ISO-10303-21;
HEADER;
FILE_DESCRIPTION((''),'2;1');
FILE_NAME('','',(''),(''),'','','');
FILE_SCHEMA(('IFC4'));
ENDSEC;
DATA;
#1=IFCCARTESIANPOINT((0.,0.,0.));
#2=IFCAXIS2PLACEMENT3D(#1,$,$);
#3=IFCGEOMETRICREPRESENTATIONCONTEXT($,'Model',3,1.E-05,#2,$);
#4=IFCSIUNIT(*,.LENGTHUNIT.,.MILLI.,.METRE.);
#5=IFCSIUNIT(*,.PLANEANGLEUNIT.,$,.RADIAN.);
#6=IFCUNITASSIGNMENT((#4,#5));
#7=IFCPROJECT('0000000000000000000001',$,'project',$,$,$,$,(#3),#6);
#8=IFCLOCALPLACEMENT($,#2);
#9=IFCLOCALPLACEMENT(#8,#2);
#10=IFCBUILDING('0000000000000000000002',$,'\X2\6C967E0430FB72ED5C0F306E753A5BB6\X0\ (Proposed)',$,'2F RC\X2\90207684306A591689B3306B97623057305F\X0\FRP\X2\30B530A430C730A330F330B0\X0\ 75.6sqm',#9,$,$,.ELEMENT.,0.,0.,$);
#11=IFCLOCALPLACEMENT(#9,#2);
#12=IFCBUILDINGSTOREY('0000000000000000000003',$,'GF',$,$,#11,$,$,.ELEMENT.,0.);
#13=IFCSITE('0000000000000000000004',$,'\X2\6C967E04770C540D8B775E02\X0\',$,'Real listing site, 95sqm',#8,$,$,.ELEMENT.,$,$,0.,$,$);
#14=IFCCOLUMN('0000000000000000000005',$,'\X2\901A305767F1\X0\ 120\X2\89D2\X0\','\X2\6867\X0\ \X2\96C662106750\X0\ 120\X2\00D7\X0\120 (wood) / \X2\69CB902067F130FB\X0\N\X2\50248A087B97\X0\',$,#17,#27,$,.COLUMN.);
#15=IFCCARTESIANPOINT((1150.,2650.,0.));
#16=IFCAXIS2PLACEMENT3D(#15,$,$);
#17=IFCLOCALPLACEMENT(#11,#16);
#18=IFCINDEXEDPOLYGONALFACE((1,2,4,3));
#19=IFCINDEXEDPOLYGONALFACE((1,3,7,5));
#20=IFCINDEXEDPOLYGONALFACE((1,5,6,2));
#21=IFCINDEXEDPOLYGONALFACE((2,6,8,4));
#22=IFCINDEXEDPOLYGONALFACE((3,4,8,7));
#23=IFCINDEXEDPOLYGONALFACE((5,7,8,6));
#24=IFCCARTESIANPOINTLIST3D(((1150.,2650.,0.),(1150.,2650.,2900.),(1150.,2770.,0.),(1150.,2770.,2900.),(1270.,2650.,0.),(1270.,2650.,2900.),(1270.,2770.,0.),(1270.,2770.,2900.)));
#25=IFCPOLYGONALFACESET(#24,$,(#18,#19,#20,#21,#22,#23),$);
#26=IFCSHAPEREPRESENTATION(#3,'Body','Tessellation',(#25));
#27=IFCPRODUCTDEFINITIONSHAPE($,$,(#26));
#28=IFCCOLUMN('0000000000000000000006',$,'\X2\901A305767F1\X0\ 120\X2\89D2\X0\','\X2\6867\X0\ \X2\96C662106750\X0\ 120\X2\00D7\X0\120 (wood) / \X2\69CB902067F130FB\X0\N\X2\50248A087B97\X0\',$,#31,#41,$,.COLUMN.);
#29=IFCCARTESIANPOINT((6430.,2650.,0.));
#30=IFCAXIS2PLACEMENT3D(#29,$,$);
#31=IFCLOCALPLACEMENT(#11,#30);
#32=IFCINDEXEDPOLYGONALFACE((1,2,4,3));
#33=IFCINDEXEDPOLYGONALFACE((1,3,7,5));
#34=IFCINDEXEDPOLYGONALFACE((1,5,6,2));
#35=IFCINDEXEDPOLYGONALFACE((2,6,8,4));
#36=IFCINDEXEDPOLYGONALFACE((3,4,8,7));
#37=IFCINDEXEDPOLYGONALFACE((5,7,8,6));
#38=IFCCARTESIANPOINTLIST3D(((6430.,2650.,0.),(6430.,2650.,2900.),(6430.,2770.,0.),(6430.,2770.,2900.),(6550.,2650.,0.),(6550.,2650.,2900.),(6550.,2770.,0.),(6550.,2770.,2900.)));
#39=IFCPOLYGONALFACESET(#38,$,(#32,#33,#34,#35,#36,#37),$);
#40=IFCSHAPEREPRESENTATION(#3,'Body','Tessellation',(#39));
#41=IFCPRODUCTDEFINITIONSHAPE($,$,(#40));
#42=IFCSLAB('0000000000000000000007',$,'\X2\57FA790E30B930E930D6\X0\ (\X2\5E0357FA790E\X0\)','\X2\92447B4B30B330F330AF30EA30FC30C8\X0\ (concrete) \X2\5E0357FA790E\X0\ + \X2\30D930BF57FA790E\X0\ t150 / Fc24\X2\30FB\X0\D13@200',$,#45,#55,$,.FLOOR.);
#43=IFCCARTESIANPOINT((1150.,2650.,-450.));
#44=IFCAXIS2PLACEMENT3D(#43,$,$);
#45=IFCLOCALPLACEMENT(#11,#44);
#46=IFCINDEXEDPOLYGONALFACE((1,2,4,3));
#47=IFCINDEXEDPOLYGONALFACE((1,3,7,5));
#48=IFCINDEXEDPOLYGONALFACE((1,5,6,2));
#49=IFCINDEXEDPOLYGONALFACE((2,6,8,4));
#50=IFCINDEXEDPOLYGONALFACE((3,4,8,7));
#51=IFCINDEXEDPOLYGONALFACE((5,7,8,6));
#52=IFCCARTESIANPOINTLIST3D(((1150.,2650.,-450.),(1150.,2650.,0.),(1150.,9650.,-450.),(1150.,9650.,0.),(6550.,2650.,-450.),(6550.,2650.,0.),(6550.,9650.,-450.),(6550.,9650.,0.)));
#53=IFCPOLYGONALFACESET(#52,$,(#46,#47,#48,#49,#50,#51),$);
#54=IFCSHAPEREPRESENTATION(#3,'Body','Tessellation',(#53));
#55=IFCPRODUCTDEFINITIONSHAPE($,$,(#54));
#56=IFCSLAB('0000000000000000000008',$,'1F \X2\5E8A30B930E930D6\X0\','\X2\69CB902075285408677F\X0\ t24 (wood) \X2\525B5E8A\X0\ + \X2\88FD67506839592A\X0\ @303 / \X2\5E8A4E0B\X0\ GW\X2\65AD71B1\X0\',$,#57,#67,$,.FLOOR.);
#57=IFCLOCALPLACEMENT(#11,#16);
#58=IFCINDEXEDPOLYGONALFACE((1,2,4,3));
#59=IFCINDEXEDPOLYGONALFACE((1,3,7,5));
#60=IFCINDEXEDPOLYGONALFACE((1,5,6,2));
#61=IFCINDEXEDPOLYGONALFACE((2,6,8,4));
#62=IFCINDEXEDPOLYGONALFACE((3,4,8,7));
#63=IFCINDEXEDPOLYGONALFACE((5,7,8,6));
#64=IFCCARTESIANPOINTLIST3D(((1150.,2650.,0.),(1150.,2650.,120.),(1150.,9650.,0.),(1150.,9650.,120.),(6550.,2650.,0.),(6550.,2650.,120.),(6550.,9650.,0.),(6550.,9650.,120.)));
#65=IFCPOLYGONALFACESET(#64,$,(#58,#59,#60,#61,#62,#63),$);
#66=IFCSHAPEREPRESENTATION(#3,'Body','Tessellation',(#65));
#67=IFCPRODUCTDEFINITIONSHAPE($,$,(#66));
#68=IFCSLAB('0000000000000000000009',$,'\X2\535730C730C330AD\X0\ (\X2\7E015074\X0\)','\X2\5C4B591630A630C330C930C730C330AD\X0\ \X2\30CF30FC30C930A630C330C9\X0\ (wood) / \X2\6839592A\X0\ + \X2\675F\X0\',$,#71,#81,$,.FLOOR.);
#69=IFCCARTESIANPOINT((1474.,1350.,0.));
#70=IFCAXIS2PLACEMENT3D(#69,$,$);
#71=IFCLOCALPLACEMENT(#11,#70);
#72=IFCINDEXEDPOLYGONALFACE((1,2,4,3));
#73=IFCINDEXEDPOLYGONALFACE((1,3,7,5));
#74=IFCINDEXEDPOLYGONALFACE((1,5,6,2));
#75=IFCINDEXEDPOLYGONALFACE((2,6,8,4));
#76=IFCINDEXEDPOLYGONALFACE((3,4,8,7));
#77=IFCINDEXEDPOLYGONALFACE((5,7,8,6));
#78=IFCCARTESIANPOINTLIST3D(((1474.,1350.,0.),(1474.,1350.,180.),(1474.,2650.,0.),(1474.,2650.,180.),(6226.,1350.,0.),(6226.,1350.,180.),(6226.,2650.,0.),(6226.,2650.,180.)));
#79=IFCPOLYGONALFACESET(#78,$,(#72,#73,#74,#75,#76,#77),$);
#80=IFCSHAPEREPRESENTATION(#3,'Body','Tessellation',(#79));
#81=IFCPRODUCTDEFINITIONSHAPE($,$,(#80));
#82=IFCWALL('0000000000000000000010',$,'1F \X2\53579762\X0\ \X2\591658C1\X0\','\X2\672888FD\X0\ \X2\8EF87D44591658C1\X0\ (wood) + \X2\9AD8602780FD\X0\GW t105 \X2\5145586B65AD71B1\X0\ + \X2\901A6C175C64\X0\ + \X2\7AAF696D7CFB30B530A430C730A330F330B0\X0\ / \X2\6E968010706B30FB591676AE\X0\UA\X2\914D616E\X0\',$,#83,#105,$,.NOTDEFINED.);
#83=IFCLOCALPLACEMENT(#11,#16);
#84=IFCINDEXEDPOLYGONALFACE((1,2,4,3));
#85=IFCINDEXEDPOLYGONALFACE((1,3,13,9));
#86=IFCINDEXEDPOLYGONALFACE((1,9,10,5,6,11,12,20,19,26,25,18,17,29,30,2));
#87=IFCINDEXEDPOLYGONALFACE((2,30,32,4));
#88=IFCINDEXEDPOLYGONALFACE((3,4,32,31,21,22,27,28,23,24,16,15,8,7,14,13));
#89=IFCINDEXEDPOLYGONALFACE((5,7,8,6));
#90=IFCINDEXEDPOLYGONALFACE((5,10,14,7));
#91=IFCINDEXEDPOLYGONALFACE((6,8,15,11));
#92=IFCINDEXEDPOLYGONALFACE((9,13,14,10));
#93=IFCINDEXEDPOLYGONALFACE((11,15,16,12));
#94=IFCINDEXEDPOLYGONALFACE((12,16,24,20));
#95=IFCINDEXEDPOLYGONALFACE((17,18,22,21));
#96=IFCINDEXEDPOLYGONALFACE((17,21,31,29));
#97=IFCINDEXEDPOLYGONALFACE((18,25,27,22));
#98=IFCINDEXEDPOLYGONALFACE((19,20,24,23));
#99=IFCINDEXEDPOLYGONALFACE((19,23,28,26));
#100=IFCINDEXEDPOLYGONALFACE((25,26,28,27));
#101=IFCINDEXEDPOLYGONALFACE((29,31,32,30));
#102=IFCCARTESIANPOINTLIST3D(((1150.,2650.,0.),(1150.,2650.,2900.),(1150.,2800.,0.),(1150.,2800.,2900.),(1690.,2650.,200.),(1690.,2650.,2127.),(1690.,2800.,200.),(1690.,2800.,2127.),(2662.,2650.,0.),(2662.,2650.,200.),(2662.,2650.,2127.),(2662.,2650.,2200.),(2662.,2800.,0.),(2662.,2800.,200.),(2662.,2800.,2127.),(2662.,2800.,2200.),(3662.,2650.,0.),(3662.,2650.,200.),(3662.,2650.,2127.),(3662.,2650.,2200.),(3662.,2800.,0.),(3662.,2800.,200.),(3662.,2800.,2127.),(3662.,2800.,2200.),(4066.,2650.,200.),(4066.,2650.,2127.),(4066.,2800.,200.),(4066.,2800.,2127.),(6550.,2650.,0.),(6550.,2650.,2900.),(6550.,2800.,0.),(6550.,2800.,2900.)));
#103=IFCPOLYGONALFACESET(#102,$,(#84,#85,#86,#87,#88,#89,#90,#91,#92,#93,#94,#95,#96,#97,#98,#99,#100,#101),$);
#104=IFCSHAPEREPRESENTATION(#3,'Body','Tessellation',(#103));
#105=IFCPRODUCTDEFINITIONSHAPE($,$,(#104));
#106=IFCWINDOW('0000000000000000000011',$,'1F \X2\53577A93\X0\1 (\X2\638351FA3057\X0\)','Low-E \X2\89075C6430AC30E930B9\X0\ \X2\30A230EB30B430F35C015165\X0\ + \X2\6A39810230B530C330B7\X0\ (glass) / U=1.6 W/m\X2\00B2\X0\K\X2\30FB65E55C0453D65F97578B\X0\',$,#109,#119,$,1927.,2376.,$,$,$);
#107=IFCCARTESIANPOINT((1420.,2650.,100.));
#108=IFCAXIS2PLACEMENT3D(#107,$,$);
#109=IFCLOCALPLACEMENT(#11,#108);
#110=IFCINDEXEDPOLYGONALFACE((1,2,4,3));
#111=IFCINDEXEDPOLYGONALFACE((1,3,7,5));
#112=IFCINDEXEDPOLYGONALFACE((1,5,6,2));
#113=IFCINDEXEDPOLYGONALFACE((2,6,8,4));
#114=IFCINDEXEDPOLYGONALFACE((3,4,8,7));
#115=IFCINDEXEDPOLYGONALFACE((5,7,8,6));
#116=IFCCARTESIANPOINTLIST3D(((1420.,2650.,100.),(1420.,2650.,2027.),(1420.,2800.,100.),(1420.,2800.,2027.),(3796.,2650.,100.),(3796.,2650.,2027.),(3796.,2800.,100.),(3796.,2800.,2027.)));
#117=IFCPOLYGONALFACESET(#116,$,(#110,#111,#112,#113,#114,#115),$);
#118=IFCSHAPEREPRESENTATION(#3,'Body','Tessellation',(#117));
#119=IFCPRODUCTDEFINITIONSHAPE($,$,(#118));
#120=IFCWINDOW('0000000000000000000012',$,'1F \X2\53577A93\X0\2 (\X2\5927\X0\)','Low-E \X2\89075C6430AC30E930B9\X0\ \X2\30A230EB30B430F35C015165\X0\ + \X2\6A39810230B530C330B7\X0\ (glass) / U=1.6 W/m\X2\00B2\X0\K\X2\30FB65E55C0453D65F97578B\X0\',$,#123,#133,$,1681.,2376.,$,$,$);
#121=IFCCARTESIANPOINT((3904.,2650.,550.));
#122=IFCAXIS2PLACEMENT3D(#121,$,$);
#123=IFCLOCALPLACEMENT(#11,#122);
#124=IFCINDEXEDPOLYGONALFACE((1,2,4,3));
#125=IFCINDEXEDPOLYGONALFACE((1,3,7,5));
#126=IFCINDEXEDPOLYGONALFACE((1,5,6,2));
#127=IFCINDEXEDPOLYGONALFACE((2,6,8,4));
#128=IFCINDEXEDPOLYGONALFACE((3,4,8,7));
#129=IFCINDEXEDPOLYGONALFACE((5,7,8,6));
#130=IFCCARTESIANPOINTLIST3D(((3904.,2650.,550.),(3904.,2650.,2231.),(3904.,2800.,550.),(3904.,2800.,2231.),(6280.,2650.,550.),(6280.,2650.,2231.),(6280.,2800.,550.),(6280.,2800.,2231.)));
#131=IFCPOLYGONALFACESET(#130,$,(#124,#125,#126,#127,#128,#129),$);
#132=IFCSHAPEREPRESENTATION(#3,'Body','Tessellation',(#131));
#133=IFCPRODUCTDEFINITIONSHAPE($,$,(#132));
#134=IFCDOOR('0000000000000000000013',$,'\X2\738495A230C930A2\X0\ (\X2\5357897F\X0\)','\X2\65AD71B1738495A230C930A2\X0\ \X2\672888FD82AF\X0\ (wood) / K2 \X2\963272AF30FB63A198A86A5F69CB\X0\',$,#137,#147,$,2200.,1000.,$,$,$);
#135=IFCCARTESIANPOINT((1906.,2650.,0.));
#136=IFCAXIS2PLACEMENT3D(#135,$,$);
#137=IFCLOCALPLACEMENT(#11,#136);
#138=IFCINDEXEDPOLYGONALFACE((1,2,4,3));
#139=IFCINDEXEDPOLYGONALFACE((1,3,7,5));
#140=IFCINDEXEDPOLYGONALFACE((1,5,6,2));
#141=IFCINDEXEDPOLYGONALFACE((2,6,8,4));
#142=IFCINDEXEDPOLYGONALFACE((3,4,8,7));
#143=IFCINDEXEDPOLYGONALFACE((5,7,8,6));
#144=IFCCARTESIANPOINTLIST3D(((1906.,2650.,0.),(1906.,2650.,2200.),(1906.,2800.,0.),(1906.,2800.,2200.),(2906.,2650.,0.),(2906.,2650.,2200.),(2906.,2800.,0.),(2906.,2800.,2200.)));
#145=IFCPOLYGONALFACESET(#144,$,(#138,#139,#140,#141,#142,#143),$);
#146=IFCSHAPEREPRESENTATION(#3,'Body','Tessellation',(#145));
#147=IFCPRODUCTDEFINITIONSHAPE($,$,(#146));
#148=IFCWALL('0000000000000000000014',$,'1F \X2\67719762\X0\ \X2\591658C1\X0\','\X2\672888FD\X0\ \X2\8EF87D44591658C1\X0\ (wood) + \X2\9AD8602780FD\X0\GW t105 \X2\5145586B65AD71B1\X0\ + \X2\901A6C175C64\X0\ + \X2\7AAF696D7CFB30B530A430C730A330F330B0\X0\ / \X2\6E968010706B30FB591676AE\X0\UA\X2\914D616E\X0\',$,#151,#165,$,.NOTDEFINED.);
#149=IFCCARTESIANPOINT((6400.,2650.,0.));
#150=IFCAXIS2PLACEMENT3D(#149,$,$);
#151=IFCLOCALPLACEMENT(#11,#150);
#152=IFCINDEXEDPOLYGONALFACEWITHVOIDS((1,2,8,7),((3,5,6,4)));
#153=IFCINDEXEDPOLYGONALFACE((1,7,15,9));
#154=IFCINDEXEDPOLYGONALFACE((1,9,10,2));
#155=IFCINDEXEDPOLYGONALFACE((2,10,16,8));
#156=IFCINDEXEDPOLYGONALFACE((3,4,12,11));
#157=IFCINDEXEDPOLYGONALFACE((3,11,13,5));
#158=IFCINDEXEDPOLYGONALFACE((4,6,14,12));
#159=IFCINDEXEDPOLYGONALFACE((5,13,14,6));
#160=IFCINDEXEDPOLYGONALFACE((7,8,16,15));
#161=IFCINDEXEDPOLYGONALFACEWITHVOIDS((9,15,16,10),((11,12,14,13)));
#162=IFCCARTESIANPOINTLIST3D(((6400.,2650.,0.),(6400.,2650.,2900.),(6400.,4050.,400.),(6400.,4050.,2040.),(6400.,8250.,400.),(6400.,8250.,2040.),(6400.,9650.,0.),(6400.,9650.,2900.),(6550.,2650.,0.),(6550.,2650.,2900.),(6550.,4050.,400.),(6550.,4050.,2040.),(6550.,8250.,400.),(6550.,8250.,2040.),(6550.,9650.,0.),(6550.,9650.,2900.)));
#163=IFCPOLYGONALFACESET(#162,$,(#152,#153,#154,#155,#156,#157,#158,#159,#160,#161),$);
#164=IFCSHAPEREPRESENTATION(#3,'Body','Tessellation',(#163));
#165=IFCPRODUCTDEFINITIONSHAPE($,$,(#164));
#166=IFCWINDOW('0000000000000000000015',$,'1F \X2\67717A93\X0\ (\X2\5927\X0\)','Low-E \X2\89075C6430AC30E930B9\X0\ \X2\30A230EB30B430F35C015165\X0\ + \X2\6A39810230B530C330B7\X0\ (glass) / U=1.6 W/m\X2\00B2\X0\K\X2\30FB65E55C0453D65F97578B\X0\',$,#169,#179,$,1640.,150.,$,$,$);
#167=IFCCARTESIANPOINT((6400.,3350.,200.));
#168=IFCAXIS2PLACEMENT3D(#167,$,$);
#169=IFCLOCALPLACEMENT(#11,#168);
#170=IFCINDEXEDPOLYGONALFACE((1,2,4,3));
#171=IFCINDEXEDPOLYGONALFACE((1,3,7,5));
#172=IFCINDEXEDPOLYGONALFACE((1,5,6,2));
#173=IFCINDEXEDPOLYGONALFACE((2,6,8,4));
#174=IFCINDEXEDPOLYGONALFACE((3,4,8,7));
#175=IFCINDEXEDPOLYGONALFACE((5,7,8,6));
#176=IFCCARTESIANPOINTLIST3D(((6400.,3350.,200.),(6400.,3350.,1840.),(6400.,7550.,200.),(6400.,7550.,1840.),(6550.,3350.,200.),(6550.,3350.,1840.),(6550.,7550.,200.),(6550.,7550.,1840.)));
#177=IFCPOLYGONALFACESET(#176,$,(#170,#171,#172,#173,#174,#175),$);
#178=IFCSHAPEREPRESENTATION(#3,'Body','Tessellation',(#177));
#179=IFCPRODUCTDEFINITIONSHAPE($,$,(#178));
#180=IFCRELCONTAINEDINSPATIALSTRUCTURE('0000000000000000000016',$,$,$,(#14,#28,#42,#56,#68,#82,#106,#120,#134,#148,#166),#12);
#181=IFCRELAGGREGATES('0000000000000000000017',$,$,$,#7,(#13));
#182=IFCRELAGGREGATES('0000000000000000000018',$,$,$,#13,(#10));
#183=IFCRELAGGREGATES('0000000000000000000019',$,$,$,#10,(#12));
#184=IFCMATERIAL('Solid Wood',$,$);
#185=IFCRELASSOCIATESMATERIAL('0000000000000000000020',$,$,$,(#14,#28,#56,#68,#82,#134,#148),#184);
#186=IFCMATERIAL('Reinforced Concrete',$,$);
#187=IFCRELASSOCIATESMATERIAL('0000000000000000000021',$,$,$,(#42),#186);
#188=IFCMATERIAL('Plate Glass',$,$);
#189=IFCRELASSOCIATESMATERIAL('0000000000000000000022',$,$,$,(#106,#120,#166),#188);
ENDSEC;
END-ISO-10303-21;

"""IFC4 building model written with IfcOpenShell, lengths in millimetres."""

from ifc_helpers import new_model, si_unit, frame, frame_2d, origin, place, context, project, spatial, rectangle, extrude, material, element, fill, save


model = new_model("IFC4")

# Units and contexts
model_context = context("Model", 3, precision=1e-05, world=origin())
ifc_project = project(units=[si_unit("LENGTHUNIT", "METRE", prefix="MILLI"), si_unit("PLANEANGLEUNIT", "RADIAN")], contexts=[model_context])

# Site, building, storey
site_placement = place(None, origin())
site = spatial("IfcSite", under=ifc_project, at=site_placement, Name="沖縄県名護市", ObjectType="Real listing site, 95sqm", CompositionType="ELEMENT", RefElevation=0.0)
building_placement = place(site_placement, origin())
building = spatial("IfcBuilding", under=site, at=building_placement, Name="沖縄・狭小の町家 (Proposed)", ObjectType="2F RC造的な外観に面したFRPサイディング 75.6sqm", CompositionType="ELEMENT", ElevationOfRefHeight=0.0, ElevationOfTerrain=0.0)
storey_placement = place(building_placement, origin())
storey = spatial("IfcBuildingStorey", under=building, at=storey_placement, Name="GF", CompositionType="ELEMENT", Elevation=0.0)

# Columns
ifc_material_1 = material(Name="Solid Wood")
column_1_placement = place(storey_placement, frame((1150.0, 2650.0, 0.0)))
element("IfcColumn", 1, at=column_1_placement, inside=storey, material=ifc_material_1, Name="通し柱 120角", Description="桧 集成材 120×120 (wood) / 構造柱・N値計算", PredefinedType="COLUMN", context=model_context, shape_type="SweptSolid", body=[
    extrude(rectangle(XDim=120.0, YDim=120.0, at=frame_2d((60.0, 60.0))), frame((1150.0, 2650.0, 0.0)), (0.0, 0.0, 1.0), 2900.0),
])
column_2_placement = place(storey_placement, frame((6430.0, 2650.0, 0.0)))
element("IfcColumn", 2, at=column_2_placement, inside=storey, material=ifc_material_1, Name="通し柱 120角", Description="桧 集成材 120×120 (wood) / 構造柱・N値計算", PredefinedType="COLUMN", context=model_context, shape_type="SweptSolid", body=[
    extrude(rectangle(XDim=120.0, YDim=120.0, at=frame_2d((60.0, 60.0))), frame((6430.0, 2650.0, 0.0)), (0.0, 0.0, 1.0), 2900.0),
])

# Slabs
ifc_material_2 = material(Name="Reinforced Concrete")
slab_1_placement = place(storey_placement, frame((1150.0, 2650.0, -450.0)))
element("IfcSlab", 3, at=slab_1_placement, inside=storey, material=ifc_material_2, Name="基礎スラブ (布基礎)", Description="鉄筋コンクリート (concrete) 布基礎 + ベタ基礎 t150 / Fc24・D13@200", PredefinedType="FLOOR", context=model_context, shape_type="SweptSolid", body=[
    extrude(rectangle(XDim=5400.0, YDim=7000.0, at=frame_2d((2700.0, 3500.0))), frame((1150.0, 2650.0, -450.0)), (0.0, 0.0, 1.0), 450.0),
])
slab_2_placement = place(storey_placement, frame((1150.0, 2650.0, 0.0)))
element("IfcSlab", 4, at=slab_2_placement, inside=storey, material=ifc_material_1, Name="1F 床スラブ", Description="構造用合板 t24 (wood) 剛床 + 製材根太 @303 / 床下 GW断熱", PredefinedType="FLOOR", context=model_context, shape_type="SweptSolid", body=[
    extrude(rectangle(XDim=5400.0, YDim=7000.0, at=frame_2d((2700.0, 3500.0))), frame((1150.0, 2650.0, 0.0)), (0.0, 0.0, 1.0), 120.0),
])
slab_3_placement = place(storey_placement, frame((1474.0, 1350.0, 0.0)))
element("IfcSlab", 5, at=slab_3_placement, inside=storey, material=ifc_material_1, Name="南デッキ (縁側)", Description="屋外ウッドデッキ ハードウッド (wood) / 根太 + 束", PredefinedType="FLOOR", context=model_context, shape_type="SweptSolid", body=[
    extrude(rectangle(XDim=4752.0, YDim=1300.0, at=frame_2d((2376.0, 650.0))), frame((1474.0, 1350.0, 0.0)), (0.0, 0.0, 1.0), 180.0),
])

# Wall, openings, windows, door
wall_1_placement = place(storey_placement, frame((1150.0, 2650.0, 0.0)))
wall_1 = element("IfcWall", 6, at=wall_1_placement, inside=storey, material=ifc_material_1, Name="1F 南面 外壁", Description="木製 軸組外壁 (wood) + 高性能GW t105 充填断熱 + 通気層 + 窯業系サイディング / 準耐火・外皮UA配慮", PredefinedType="NOTDEFINED", context=model_context, shape_type="SweptSolid", body=[
    extrude(rectangle(XDim=5400.0, YDim=150.0, at=frame_2d((2700.0, 75.0))), frame((1150.0, 2650.0, 0.0)), (0.0, 0.0, 1.0), 2900.0),
])
opening_1_placement = place(storey_placement, frame((1420.0, 2650.0, 100.0)))
opening_1 = element("IfcOpeningElement", 7, at=opening_1_placement, cuts=wall_1, PredefinedType="NOTDEFINED", context=model_context, shape_type="SweptSolid", body=[
    extrude(rectangle(XDim=2376.0, YDim=150.0, at=frame_2d((1188.0, 75.0))), frame((1420.0, 2650.0, 100.0)), (0.0, 0.0, 1.0), 1927.0),
])
opening_2_placement = place(storey_placement, frame((3904.0, 2650.0, 550.0)))
opening_2 = element("IfcOpeningElement", 8, at=opening_2_placement, cuts=wall_1, PredefinedType="NOTDEFINED", context=model_context, shape_type="SweptSolid", body=[
    extrude(rectangle(XDim=2376.0, YDim=150.0, at=frame_2d((1188.0, 75.0))), frame((3904.0, 2650.0, 550.0)), (0.0, 0.0, 1.0), 1681.0),
])
opening_3_placement = place(storey_placement, frame((1906.0, 2650.0, 0.0)))
opening_3 = element("IfcOpeningElement", 9, at=opening_3_placement, cuts=wall_1, PredefinedType="NOTDEFINED", context=model_context, shape_type="SweptSolid", body=[
    extrude(rectangle(XDim=1000.0, YDim=150.0, at=frame_2d((500.0, 75.0))), frame((1906.0, 2650.0, 0.0)), (0.0, 0.0, 1.0), 2200.0),
])
ifc_material_3 = material(Name="Plate Glass")
window_1_placement = place(storey_placement, frame((1420.0, 2650.0, 100.0)))
window_1 = element("IfcWindow", 10, at=window_1_placement, inside=storey, material=ifc_material_3, Name="1F 南窓1 (掃出し)", Description="Low-E 複層ガラス アルゴン封入 + 樹脂サッシ (glass) / U=1.6 W/m²K・日射取得型", OverallHeight=1927.0, OverallWidth=2376.0, context=model_context, shape_type="SweptSolid", body=[
    extrude(rectangle(XDim=2376.0, YDim=150.0, at=frame_2d((1188.0, 75.0))), frame((1420.0, 2650.0, 100.0)), (0.0, 0.0, 1.0), 1927.0),
])
fill(opening_1, window_1)
window_2_placement = place(storey_placement, frame((3904.0, 2650.0, 550.0)))
window_2 = element("IfcWindow", 11, at=window_2_placement, inside=storey, material=ifc_material_3, Name="1F 南窓2 (大)", Description="Low-E 複層ガラス アルゴン封入 + 樹脂サッシ (glass) / U=1.6 W/m²K・日射取得型", OverallHeight=1681.0, OverallWidth=2376.0, context=model_context, shape_type="SweptSolid", body=[
    extrude(rectangle(XDim=2376.0, YDim=150.0, at=frame_2d((1188.0, 75.0))), frame((3904.0, 2650.0, 550.0)), (0.0, 0.0, 1.0), 1681.0),
])
fill(opening_2, window_2)
door_placement = place(storey_placement, frame((1906.0, 2650.0, 0.0)))
door = element("IfcDoor", 12, at=door_placement, inside=storey, material=ifc_material_1, Name="玄関ドア (南西)", Description="断熱玄関ドア 木製芯 (wood) / K2 防犯・採風機構", OverallHeight=2200.0, OverallWidth=1000.0, context=model_context, shape_type="SweptSolid", body=[
    extrude(rectangle(XDim=1000.0, YDim=150.0, at=frame_2d((500.0, 75.0))), frame((1906.0, 2650.0, 0.0)), (0.0, 0.0, 1.0), 2200.0),
])
fill(opening_3, door)

# Wall, opening, window
wall_2_placement = place(storey_placement, frame((6400.0, 2650.0, 0.0)))
wall_2 = element("IfcWall", 13, at=wall_2_placement, inside=storey, material=ifc_material_1, Name="1F 東面 外壁", Description="木製 軸組外壁 (wood) + 高性能GW t105 充填断熱 + 通気層 + 窯業系サイディング / 準耐火・外皮UA配慮", PredefinedType="NOTDEFINED", context=model_context, shape_type="SweptSolid", body=[
    extrude(rectangle(XDim=150.0, YDim=7000.0, at=frame_2d((75.0, 3500.0))), frame((6400.0, 2650.0, 0.0)), (0.0, 0.0, 1.0), 2900.0),
])
opening_4_placement = place(storey_placement, frame((6400.0, 3350.0, 200.0)))
opening_4 = element("IfcOpeningElement", 14, at=opening_4_placement, cuts=wall_2, PredefinedType="NOTDEFINED", context=model_context, shape_type="SweptSolid", body=[
    extrude(rectangle(XDim=150.0, YDim=4200.0, at=frame_2d((75.0, 2100.0))), frame((6400.0, 3350.0, 200.0)), (0.0, 0.0, 1.0), 1640.0),
])
window_3_placement = place(storey_placement, frame((6400.0, 3350.0, 200.0)))
window_3 = element("IfcWindow", 15, at=window_3_placement, inside=storey, material=ifc_material_3, Name="1F 東窓 (大)", Description="Low-E 複層ガラス アルゴン封入 + 樹脂サッシ (glass) / U=1.6 W/m²K・日射取得型", OverallHeight=1640.0, OverallWidth=150.0, context=model_context, shape_type="SweptSolid", body=[
    extrude(rectangle(XDim=150.0, YDim=4200.0, at=frame_2d((75.0, 2100.0))), frame((6400.0, 3350.0, 200.0)), (0.0, 0.0, 1.0), 1640.0),
])
fill(opening_4, window_3)

save(model, "model.ifc")
